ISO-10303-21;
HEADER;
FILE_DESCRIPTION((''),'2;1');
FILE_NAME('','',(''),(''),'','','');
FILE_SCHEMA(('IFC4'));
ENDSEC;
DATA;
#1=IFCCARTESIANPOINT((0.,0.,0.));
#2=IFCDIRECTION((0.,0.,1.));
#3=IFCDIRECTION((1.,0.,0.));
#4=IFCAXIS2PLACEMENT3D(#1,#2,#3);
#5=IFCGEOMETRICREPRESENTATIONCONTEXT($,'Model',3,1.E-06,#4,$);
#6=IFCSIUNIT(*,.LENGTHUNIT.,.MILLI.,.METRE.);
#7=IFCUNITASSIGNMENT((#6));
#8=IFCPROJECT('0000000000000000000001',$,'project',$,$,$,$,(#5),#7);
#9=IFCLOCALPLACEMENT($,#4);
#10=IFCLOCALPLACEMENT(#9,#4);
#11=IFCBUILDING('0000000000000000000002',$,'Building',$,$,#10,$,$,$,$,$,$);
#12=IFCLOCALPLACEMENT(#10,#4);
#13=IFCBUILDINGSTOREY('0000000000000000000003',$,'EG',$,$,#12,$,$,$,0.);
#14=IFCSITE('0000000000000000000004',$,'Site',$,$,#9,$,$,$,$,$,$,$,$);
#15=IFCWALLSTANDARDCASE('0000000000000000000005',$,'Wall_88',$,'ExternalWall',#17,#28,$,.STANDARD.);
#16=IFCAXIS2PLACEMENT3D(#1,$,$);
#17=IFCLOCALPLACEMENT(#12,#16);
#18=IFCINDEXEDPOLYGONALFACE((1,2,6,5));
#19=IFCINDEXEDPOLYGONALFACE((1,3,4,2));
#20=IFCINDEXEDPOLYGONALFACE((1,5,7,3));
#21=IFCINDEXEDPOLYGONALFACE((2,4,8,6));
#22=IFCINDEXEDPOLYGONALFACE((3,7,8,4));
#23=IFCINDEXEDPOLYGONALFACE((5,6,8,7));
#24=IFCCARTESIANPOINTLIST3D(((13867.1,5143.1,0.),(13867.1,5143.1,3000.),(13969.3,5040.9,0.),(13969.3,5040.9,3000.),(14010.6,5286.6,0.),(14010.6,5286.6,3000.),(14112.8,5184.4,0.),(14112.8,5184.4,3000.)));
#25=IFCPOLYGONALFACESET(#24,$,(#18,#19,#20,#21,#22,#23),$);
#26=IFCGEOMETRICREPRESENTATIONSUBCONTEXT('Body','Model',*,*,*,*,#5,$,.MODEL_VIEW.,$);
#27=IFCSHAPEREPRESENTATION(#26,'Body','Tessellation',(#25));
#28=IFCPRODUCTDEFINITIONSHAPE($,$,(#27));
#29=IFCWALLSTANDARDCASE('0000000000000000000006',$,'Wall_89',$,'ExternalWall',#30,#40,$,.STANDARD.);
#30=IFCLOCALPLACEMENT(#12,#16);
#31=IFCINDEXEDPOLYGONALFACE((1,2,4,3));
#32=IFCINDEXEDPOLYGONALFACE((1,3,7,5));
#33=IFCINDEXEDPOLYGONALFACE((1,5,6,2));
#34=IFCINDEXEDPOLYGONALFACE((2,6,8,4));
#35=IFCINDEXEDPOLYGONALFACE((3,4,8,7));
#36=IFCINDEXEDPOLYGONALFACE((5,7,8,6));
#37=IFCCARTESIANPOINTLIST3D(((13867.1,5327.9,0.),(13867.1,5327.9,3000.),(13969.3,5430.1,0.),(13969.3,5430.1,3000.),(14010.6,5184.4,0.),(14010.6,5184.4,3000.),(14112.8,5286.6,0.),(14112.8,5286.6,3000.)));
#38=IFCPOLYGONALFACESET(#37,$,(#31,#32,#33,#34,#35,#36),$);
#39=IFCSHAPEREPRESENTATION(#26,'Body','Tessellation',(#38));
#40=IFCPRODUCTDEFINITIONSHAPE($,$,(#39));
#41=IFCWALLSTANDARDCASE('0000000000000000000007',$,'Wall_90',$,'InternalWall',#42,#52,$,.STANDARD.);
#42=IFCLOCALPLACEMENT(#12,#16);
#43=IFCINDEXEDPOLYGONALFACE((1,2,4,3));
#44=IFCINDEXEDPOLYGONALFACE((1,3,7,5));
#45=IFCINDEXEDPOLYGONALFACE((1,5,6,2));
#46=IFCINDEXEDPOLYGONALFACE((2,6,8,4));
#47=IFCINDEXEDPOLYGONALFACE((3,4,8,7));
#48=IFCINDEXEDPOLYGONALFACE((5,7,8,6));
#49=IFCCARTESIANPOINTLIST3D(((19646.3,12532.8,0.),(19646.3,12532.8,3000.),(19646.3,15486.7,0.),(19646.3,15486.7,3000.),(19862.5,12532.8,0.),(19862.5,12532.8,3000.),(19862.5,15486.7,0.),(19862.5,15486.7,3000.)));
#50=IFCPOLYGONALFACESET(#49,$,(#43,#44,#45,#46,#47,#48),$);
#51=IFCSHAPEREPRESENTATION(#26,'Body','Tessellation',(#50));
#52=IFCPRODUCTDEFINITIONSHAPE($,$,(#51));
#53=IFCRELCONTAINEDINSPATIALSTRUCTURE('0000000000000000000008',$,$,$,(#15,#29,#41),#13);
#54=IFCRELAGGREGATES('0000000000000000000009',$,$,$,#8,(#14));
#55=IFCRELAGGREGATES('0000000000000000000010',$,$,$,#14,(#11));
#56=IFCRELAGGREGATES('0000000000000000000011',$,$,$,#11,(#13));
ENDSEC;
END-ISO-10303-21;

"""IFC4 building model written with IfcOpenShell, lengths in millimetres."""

from ifc_helpers import new_model, si_unit, frame, origin_with_axes, place, context, subcontext, project, spatial, rectangle, extrude, element, save


model = new_model("IFC4")

# Units and contexts
model_context = context("Model", 3, precision=1e-06, world=origin_with_axes())
body_context = subcontext(model_context, "Body", "Model", "MODEL_VIEW")
ifc_project = project(units=[si_unit("LENGTHUNIT", "METRE", prefix="MILLI")], contexts=[model_context])

# Site, building, storey
site_placement = place(None, origin_with_axes())
site = spatial("IfcSite", under=ifc_project, at=site_placement, Name="Site")
building_placement = place(site_placement, origin_with_axes())
building = spatial("IfcBuilding", under=site, at=building_placement, Name="Building")
storey_placement = place(building_placement, origin_with_axes())
storey = spatial("IfcBuildingStorey", under=building, at=storey_placement, Name="EG", Elevation=0.0)

# Walls
wall_1_placement = place(storey_placement, origin_with_axes())
element("IfcWallStandardCase", 1, at=wall_1_placement, inside=storey, Name="Wall_88", ObjectType="ExternalWall", PredefinedType="STANDARD", context=body_context, shape_type="SweptSolid", body=[
    extrude(rectangle(XDim=202.9, YDim=144.5), frame((13990.0, 5163.8, 0.0), z_axis=(0.0, 0.0, 1.0), x_axis=(-0.707107, -0.707107, 0.0)), (0.0, 0.0, 1.0), 3000.0),
])
wall_2_placement = place(storey_placement, origin_with_axes())
element("IfcWallStandardCase", 2, at=wall_2_placement, inside=storey, Name="Wall_89", ObjectType="ExternalWall", PredefinedType="STANDARD", context=body_context, shape_type="SweptSolid", body=[
    extrude(rectangle(XDim=202.9, YDim=144.5), frame((13990.0, 5307.3, 0.0), z_axis=(0.0, 0.0, 1.0), x_axis=(-0.707107, 0.707107, 0.0)), (0.0, 0.0, 1.0), 3000.0),
])
wall_3_placement = place(storey_placement, origin_with_axes())
element("IfcWallStandardCase", 3, at=wall_3_placement, inside=storey, Name="Wall_90", ObjectType="InternalWall", PredefinedType="STANDARD", context=body_context, shape_type="SweptSolid", body=[
    extrude(rectangle(XDim=2953.9, YDim=216.2), frame((19754.4, 14009.7, 0.0), z_axis=(0.0, 0.0, 1.0), x_axis=(0.0, -1.0, 0.0)), (0.0, 0.0, 1.0), 3000.0),
])

save(model, "model.ifc")
